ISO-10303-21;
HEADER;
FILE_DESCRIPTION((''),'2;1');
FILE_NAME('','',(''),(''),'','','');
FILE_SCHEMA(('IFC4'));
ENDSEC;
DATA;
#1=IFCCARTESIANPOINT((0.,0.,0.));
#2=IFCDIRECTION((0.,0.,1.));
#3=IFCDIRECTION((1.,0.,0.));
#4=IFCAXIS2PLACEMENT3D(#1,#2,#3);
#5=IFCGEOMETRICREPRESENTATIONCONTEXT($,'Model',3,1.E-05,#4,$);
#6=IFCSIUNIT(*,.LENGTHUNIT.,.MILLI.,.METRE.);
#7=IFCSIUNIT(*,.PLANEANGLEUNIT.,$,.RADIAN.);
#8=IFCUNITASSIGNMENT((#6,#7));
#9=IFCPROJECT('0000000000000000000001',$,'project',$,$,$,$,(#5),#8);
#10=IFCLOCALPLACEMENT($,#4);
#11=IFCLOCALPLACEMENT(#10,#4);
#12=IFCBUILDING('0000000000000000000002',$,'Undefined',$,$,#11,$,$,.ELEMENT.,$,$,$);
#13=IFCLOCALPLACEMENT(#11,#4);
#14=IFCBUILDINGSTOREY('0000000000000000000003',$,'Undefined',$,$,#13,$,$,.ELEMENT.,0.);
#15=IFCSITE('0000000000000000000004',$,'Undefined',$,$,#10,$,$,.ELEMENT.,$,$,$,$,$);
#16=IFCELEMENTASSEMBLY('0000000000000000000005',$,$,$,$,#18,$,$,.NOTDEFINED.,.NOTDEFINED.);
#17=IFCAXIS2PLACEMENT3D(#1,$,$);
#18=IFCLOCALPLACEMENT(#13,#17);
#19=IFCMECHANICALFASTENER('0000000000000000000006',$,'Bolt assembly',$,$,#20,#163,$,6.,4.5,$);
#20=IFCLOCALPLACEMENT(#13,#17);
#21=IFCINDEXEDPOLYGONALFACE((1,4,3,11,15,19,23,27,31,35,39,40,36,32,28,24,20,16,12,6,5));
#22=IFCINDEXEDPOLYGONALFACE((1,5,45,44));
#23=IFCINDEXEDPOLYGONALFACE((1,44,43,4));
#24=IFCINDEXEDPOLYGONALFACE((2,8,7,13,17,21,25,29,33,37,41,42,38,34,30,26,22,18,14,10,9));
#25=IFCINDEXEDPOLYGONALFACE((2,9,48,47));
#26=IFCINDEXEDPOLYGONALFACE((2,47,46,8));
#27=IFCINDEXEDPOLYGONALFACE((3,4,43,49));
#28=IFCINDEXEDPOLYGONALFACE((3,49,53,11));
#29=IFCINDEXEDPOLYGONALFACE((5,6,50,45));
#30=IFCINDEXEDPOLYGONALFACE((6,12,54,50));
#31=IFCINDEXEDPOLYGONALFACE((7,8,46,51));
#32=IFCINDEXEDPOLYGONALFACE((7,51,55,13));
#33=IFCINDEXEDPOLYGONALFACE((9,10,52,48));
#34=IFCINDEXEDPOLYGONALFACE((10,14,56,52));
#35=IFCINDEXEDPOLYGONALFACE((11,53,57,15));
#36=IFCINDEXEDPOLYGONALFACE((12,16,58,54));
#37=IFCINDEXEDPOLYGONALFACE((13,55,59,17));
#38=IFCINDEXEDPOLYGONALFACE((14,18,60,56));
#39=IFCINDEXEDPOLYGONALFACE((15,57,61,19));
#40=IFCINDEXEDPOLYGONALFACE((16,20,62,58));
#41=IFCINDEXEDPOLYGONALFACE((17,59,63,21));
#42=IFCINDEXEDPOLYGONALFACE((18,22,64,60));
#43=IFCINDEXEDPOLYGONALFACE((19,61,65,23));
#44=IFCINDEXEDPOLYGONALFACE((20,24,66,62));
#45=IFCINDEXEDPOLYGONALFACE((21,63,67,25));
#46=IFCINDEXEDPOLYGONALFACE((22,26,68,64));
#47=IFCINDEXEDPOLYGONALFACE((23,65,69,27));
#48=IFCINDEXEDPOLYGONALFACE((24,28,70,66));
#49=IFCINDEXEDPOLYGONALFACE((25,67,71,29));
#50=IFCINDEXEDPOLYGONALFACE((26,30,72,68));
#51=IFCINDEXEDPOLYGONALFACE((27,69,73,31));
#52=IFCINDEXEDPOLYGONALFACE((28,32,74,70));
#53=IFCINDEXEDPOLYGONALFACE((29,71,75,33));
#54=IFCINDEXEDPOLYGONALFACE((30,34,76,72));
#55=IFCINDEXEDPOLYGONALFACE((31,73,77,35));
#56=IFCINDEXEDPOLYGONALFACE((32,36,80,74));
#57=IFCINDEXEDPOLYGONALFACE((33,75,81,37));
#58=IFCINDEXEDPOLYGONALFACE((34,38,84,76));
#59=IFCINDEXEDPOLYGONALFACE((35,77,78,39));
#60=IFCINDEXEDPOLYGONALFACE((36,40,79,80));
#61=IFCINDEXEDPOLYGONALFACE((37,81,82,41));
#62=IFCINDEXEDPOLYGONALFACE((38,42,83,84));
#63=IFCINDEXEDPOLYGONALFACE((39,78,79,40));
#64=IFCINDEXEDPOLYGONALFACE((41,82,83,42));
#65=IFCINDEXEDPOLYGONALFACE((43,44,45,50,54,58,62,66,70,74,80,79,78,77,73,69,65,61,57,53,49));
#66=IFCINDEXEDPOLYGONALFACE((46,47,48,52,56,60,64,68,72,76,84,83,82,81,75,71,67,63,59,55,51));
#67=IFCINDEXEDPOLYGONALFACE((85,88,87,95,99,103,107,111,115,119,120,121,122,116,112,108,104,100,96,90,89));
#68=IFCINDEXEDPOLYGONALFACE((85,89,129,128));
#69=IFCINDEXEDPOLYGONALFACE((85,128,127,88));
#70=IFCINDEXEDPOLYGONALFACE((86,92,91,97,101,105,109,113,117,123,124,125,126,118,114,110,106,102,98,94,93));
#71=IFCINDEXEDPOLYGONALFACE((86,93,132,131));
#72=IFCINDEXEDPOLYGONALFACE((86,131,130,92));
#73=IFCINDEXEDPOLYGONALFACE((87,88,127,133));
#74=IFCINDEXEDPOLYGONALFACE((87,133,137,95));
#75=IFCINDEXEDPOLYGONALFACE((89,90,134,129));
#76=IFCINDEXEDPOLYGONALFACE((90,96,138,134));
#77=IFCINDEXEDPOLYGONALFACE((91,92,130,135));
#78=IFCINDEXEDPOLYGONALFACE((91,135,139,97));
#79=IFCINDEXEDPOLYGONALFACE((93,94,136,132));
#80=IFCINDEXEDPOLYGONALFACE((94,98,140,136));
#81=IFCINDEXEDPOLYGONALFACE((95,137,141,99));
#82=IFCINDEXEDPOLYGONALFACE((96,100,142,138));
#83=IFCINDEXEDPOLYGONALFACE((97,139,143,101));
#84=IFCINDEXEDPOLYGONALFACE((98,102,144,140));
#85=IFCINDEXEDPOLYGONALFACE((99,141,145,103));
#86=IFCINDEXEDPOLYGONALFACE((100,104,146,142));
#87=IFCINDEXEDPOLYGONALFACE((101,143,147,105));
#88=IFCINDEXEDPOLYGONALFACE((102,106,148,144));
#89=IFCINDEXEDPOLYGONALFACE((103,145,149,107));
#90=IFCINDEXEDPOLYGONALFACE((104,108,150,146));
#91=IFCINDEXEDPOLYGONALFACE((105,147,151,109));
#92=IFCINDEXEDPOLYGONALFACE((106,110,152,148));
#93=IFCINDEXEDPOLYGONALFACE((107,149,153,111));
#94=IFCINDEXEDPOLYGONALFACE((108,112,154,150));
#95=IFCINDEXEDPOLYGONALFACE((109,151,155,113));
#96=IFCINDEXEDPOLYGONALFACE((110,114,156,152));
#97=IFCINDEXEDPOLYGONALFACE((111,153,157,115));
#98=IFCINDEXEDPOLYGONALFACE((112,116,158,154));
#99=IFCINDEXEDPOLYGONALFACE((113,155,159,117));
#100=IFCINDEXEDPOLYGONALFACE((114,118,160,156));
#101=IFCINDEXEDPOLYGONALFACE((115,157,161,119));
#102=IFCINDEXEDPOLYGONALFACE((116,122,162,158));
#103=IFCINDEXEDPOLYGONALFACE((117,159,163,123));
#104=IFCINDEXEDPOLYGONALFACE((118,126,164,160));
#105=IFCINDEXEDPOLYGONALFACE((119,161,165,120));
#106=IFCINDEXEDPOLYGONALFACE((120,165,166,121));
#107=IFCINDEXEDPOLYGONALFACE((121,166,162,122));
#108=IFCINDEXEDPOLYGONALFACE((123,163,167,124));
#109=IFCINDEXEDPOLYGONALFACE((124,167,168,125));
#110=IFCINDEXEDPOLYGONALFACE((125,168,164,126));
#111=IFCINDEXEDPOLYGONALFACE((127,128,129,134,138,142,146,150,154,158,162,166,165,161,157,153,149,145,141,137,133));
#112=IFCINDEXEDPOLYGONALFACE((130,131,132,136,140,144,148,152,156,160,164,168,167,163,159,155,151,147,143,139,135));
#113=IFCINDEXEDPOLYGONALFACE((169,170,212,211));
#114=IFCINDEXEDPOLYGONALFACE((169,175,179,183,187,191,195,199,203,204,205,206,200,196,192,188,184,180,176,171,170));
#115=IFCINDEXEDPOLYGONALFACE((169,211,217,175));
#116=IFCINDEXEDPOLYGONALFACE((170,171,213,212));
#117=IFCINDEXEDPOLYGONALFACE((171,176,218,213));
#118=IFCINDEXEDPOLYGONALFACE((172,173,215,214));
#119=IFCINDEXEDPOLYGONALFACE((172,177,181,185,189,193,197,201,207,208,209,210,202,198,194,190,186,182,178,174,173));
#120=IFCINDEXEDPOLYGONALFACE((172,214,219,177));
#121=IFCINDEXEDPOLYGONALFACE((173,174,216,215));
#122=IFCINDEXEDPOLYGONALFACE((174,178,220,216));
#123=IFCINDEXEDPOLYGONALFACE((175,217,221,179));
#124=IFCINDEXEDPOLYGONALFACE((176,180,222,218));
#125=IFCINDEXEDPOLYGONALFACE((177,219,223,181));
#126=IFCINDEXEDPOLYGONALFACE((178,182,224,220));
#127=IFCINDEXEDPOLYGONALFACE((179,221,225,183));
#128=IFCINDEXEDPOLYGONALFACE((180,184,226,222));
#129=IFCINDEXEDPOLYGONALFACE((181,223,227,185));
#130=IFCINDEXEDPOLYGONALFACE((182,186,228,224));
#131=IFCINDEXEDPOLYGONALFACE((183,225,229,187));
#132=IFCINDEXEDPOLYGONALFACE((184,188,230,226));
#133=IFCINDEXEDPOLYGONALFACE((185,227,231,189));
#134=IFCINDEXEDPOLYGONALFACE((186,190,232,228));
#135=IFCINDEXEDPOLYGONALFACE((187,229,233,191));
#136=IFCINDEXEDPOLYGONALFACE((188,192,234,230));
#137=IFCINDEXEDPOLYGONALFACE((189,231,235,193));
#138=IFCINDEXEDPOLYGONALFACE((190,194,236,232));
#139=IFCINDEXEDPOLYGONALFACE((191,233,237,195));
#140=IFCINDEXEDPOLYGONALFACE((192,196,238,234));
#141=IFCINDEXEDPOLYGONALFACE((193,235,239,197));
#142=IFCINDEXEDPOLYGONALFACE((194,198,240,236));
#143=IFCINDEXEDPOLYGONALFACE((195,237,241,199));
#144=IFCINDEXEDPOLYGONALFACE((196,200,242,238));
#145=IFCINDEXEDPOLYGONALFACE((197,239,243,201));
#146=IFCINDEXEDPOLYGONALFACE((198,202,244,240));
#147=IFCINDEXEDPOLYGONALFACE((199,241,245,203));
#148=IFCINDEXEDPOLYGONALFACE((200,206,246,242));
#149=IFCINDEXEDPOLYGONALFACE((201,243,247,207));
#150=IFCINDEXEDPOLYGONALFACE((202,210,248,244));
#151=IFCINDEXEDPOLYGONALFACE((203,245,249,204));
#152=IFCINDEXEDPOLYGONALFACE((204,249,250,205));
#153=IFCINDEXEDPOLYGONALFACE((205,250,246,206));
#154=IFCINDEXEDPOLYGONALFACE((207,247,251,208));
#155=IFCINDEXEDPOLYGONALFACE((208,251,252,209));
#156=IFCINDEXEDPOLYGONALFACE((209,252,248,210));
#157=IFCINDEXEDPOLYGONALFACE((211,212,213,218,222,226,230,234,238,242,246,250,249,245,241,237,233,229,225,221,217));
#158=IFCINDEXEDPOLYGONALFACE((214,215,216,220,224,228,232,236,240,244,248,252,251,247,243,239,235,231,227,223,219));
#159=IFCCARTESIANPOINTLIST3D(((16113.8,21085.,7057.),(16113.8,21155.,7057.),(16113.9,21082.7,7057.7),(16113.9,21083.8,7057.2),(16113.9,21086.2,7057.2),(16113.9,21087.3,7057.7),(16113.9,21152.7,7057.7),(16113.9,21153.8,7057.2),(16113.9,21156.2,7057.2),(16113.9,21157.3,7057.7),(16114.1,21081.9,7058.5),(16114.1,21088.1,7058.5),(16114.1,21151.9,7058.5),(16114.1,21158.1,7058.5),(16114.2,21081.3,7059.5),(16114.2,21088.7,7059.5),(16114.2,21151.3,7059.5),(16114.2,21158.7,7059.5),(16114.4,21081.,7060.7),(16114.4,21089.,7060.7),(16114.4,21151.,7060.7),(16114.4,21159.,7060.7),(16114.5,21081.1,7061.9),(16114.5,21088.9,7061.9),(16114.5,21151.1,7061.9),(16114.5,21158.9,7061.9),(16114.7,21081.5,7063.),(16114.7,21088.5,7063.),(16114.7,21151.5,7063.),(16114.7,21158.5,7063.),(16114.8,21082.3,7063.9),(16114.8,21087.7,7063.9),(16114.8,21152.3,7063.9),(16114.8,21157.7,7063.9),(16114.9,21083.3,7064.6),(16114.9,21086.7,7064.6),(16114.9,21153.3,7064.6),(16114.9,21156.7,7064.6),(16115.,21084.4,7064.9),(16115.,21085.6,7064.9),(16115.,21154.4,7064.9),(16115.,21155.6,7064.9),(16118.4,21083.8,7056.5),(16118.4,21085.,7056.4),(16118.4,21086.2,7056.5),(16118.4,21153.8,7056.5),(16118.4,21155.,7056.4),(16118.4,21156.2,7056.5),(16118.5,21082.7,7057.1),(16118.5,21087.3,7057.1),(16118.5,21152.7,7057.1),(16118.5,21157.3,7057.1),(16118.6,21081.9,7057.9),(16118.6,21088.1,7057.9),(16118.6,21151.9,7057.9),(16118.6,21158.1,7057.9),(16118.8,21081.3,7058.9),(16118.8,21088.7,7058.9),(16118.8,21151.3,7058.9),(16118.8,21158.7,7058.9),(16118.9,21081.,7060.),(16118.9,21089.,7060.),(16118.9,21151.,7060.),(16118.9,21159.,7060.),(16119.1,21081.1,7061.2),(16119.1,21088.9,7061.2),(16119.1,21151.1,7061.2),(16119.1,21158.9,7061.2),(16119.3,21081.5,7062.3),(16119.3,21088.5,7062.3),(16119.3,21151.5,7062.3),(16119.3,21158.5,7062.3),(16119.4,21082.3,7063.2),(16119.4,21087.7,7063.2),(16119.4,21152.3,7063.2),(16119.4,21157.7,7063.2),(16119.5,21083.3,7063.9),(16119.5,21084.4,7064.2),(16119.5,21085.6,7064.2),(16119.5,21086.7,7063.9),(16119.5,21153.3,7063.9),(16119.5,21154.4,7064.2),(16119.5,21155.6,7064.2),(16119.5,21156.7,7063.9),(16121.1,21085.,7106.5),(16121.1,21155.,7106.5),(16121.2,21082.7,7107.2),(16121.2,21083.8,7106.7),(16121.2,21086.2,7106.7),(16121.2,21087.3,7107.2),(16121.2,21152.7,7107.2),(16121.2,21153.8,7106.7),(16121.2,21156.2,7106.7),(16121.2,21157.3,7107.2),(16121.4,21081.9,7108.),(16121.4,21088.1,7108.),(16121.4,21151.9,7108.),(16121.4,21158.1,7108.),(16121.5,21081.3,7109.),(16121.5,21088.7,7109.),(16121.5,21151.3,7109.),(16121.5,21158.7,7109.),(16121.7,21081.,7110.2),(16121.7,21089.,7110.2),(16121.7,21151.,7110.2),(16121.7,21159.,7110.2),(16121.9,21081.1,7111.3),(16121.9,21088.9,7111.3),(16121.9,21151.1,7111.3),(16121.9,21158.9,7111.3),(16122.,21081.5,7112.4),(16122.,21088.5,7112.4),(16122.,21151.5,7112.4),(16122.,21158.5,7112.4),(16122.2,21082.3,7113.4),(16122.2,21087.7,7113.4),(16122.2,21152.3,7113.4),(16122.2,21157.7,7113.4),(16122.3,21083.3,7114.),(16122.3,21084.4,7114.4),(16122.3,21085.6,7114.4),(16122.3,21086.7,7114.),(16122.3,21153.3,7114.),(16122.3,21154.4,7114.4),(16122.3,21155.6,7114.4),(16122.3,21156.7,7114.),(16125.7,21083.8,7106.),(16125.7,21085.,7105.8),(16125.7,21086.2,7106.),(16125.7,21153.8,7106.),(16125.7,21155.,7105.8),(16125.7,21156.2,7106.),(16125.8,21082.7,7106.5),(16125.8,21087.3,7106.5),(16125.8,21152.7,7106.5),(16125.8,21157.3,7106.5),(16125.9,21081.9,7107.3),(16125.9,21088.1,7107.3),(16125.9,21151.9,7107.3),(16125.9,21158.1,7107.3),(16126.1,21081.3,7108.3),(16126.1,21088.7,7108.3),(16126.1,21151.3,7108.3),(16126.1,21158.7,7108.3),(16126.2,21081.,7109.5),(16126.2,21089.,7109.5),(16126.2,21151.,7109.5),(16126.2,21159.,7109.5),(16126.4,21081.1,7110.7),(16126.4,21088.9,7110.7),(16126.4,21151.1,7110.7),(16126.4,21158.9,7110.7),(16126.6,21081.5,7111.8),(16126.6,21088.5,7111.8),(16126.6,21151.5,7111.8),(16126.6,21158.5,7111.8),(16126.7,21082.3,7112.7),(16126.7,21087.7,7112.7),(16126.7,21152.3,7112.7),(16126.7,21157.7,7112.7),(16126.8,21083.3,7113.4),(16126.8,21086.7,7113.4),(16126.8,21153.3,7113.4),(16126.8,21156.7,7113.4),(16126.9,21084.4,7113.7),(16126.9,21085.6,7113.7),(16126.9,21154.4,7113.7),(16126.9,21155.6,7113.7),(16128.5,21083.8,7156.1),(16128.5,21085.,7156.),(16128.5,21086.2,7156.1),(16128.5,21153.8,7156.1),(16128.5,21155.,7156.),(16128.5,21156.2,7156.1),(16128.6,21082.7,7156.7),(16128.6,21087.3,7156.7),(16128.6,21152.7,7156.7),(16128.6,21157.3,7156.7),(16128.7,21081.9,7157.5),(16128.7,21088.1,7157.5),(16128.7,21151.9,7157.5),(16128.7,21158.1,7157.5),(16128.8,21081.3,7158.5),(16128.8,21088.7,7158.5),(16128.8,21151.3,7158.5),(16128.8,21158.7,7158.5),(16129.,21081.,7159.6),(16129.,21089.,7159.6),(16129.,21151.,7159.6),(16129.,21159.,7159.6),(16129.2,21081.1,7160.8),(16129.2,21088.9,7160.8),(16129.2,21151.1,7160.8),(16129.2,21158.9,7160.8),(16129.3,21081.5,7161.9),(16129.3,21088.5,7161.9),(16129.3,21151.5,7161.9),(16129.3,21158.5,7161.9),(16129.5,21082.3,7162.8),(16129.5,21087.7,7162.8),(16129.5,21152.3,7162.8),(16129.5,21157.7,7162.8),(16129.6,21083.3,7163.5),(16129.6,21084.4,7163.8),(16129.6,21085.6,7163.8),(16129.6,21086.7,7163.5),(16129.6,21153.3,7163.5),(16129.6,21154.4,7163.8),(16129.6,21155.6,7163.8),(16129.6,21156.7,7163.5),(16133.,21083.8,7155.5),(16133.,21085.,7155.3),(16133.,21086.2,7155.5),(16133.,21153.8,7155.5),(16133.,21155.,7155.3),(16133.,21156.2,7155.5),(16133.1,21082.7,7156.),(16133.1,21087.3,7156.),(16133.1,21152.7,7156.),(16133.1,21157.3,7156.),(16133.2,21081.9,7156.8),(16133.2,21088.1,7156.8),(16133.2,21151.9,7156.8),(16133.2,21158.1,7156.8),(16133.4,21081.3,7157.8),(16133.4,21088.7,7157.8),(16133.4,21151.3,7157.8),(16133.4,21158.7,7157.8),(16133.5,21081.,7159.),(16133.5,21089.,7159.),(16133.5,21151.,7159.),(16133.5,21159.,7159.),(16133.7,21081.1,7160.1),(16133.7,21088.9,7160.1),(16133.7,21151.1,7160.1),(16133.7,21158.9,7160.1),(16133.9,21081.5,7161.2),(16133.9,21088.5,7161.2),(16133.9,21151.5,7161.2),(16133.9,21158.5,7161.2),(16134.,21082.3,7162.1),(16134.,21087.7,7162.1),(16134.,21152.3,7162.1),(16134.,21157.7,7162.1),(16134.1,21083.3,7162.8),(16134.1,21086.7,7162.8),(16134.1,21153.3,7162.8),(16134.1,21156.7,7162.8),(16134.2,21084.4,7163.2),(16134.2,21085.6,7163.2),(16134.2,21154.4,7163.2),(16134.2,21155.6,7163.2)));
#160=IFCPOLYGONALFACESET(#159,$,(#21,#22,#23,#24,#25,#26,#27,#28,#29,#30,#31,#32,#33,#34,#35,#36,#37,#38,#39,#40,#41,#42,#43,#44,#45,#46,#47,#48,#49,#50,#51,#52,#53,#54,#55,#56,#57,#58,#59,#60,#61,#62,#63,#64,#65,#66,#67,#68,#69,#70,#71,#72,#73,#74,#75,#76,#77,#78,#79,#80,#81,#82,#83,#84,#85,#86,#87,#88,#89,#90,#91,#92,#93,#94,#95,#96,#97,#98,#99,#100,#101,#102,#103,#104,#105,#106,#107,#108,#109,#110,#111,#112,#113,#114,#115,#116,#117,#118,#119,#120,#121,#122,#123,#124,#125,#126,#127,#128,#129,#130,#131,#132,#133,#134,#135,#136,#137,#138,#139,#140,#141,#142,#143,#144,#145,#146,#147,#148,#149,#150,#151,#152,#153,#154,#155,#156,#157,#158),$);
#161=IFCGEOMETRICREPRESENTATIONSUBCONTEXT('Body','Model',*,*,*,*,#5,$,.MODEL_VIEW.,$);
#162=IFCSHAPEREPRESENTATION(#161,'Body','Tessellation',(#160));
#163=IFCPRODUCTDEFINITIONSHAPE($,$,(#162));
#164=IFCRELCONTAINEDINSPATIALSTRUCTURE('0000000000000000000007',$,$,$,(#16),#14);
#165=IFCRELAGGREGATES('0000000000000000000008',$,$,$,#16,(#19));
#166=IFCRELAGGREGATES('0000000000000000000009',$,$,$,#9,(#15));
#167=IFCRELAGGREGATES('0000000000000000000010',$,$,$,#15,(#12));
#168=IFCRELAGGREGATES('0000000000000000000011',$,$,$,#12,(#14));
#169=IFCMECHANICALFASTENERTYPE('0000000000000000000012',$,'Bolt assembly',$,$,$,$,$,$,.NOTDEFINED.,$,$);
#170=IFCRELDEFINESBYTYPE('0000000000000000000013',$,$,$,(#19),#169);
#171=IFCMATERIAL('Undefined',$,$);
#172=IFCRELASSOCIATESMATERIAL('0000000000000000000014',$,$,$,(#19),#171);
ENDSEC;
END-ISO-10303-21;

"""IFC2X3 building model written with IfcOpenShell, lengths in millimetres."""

from ifc_helpers import new_model, si_unit, frame, origin_with_axes, origin_2d_with_axis, place, context, subcontext, project, spatial, circle, extrude, source, transform, mapped, material, type_object, element, aggregate, save


model = new_model("IFC2X3")

# Units and contexts
model_context = context("Model", 3, precision=1e-05, world=origin_with_axes())
body_context = subcontext(model_context, "Body", "Model", "MODEL_VIEW")
ifc_project = project(units=[si_unit("LENGTHUNIT", "METRE", prefix="MILLI"), si_unit("PLANEANGLEUNIT", "RADIAN")], contexts=[model_context])

# Site, building, storey
site_placement = place(None, origin_with_axes())
site = spatial("IfcSite", under=ifc_project, at=site_placement, Name="Undefined", CompositionType="ELEMENT")
building_placement = place(site_placement, origin_with_axes())
building = spatial("IfcBuilding", under=site, at=building_placement, Name="Undefined", CompositionType="ELEMENT")
storey_placement = place(building_placement, origin_with_axes())
storey = spatial("IfcBuildingStorey", under=building, at=storey_placement, Name="Undefined", CompositionType="ELEMENT", Elevation=0.0)

# Element assembly
assembly_1_placement = place(storey_placement, origin_with_axes())
assembly_1 = element("IfcElementAssembly", 1, at=assembly_1_placement, inside=storey, AssemblyPlace="NOTDEFINED", PredefinedType="NOTDEFINED")

# Mechanical fastener
ifc_material_1 = material(Name="Undefined")
mechanical_fastener_type = type_object("IfcMechanicalFastenerType", Name="Bolt assembly")
shared_shape_1 = source(origin_with_axes(), body_context, "Body", "SweptSolid", [
    extrude(circle(Radius=4.0, at=origin_2d_with_axis()), frame((0.0, 0.0, 0.0), z_axis=(0.0, 1.0, 0.0), x_axis=(1.0, 0.0, 0.0)), (0.0, 0.0, 1.0), 4.6),
])
mechanical_fastener_1_placement = place(assembly_1_placement, frame((16133.6, 21120.0, 7159.2), z_axis=(0.0, 1.0, 0.0), x_axis=(-0.146202, 0.0, -0.989255)))
mechanical_fastener_1 = element("IfcMechanicalFastener", 2, at=mechanical_fastener_1_placement, type_object=mechanical_fastener_type, material=ifc_material_1, Name="Bolt assembly", NominalDiameter=6.0, NominalLength=4.5, context=body_context, shape_type="MappedRepresentation", body=[
    mapped(shared_shape_1, transform((0.0, 0.0, 35.0))),
    mapped(shared_shape_1, transform((50.0, 0.0, 35.0))),
    mapped(shared_shape_1, transform((100.0, 0.0, 35.0))),
    mapped(shared_shape_1, transform((0.0, 0.0, -35.0))),
    mapped(shared_shape_1, transform((50.0, 0.0, -35.0))),
    mapped(shared_shape_1, transform((100.0, 0.0, -35.0))),
])

aggregate(assembly_1, [mechanical_fastener_1])

save(model, "model.ifc")
